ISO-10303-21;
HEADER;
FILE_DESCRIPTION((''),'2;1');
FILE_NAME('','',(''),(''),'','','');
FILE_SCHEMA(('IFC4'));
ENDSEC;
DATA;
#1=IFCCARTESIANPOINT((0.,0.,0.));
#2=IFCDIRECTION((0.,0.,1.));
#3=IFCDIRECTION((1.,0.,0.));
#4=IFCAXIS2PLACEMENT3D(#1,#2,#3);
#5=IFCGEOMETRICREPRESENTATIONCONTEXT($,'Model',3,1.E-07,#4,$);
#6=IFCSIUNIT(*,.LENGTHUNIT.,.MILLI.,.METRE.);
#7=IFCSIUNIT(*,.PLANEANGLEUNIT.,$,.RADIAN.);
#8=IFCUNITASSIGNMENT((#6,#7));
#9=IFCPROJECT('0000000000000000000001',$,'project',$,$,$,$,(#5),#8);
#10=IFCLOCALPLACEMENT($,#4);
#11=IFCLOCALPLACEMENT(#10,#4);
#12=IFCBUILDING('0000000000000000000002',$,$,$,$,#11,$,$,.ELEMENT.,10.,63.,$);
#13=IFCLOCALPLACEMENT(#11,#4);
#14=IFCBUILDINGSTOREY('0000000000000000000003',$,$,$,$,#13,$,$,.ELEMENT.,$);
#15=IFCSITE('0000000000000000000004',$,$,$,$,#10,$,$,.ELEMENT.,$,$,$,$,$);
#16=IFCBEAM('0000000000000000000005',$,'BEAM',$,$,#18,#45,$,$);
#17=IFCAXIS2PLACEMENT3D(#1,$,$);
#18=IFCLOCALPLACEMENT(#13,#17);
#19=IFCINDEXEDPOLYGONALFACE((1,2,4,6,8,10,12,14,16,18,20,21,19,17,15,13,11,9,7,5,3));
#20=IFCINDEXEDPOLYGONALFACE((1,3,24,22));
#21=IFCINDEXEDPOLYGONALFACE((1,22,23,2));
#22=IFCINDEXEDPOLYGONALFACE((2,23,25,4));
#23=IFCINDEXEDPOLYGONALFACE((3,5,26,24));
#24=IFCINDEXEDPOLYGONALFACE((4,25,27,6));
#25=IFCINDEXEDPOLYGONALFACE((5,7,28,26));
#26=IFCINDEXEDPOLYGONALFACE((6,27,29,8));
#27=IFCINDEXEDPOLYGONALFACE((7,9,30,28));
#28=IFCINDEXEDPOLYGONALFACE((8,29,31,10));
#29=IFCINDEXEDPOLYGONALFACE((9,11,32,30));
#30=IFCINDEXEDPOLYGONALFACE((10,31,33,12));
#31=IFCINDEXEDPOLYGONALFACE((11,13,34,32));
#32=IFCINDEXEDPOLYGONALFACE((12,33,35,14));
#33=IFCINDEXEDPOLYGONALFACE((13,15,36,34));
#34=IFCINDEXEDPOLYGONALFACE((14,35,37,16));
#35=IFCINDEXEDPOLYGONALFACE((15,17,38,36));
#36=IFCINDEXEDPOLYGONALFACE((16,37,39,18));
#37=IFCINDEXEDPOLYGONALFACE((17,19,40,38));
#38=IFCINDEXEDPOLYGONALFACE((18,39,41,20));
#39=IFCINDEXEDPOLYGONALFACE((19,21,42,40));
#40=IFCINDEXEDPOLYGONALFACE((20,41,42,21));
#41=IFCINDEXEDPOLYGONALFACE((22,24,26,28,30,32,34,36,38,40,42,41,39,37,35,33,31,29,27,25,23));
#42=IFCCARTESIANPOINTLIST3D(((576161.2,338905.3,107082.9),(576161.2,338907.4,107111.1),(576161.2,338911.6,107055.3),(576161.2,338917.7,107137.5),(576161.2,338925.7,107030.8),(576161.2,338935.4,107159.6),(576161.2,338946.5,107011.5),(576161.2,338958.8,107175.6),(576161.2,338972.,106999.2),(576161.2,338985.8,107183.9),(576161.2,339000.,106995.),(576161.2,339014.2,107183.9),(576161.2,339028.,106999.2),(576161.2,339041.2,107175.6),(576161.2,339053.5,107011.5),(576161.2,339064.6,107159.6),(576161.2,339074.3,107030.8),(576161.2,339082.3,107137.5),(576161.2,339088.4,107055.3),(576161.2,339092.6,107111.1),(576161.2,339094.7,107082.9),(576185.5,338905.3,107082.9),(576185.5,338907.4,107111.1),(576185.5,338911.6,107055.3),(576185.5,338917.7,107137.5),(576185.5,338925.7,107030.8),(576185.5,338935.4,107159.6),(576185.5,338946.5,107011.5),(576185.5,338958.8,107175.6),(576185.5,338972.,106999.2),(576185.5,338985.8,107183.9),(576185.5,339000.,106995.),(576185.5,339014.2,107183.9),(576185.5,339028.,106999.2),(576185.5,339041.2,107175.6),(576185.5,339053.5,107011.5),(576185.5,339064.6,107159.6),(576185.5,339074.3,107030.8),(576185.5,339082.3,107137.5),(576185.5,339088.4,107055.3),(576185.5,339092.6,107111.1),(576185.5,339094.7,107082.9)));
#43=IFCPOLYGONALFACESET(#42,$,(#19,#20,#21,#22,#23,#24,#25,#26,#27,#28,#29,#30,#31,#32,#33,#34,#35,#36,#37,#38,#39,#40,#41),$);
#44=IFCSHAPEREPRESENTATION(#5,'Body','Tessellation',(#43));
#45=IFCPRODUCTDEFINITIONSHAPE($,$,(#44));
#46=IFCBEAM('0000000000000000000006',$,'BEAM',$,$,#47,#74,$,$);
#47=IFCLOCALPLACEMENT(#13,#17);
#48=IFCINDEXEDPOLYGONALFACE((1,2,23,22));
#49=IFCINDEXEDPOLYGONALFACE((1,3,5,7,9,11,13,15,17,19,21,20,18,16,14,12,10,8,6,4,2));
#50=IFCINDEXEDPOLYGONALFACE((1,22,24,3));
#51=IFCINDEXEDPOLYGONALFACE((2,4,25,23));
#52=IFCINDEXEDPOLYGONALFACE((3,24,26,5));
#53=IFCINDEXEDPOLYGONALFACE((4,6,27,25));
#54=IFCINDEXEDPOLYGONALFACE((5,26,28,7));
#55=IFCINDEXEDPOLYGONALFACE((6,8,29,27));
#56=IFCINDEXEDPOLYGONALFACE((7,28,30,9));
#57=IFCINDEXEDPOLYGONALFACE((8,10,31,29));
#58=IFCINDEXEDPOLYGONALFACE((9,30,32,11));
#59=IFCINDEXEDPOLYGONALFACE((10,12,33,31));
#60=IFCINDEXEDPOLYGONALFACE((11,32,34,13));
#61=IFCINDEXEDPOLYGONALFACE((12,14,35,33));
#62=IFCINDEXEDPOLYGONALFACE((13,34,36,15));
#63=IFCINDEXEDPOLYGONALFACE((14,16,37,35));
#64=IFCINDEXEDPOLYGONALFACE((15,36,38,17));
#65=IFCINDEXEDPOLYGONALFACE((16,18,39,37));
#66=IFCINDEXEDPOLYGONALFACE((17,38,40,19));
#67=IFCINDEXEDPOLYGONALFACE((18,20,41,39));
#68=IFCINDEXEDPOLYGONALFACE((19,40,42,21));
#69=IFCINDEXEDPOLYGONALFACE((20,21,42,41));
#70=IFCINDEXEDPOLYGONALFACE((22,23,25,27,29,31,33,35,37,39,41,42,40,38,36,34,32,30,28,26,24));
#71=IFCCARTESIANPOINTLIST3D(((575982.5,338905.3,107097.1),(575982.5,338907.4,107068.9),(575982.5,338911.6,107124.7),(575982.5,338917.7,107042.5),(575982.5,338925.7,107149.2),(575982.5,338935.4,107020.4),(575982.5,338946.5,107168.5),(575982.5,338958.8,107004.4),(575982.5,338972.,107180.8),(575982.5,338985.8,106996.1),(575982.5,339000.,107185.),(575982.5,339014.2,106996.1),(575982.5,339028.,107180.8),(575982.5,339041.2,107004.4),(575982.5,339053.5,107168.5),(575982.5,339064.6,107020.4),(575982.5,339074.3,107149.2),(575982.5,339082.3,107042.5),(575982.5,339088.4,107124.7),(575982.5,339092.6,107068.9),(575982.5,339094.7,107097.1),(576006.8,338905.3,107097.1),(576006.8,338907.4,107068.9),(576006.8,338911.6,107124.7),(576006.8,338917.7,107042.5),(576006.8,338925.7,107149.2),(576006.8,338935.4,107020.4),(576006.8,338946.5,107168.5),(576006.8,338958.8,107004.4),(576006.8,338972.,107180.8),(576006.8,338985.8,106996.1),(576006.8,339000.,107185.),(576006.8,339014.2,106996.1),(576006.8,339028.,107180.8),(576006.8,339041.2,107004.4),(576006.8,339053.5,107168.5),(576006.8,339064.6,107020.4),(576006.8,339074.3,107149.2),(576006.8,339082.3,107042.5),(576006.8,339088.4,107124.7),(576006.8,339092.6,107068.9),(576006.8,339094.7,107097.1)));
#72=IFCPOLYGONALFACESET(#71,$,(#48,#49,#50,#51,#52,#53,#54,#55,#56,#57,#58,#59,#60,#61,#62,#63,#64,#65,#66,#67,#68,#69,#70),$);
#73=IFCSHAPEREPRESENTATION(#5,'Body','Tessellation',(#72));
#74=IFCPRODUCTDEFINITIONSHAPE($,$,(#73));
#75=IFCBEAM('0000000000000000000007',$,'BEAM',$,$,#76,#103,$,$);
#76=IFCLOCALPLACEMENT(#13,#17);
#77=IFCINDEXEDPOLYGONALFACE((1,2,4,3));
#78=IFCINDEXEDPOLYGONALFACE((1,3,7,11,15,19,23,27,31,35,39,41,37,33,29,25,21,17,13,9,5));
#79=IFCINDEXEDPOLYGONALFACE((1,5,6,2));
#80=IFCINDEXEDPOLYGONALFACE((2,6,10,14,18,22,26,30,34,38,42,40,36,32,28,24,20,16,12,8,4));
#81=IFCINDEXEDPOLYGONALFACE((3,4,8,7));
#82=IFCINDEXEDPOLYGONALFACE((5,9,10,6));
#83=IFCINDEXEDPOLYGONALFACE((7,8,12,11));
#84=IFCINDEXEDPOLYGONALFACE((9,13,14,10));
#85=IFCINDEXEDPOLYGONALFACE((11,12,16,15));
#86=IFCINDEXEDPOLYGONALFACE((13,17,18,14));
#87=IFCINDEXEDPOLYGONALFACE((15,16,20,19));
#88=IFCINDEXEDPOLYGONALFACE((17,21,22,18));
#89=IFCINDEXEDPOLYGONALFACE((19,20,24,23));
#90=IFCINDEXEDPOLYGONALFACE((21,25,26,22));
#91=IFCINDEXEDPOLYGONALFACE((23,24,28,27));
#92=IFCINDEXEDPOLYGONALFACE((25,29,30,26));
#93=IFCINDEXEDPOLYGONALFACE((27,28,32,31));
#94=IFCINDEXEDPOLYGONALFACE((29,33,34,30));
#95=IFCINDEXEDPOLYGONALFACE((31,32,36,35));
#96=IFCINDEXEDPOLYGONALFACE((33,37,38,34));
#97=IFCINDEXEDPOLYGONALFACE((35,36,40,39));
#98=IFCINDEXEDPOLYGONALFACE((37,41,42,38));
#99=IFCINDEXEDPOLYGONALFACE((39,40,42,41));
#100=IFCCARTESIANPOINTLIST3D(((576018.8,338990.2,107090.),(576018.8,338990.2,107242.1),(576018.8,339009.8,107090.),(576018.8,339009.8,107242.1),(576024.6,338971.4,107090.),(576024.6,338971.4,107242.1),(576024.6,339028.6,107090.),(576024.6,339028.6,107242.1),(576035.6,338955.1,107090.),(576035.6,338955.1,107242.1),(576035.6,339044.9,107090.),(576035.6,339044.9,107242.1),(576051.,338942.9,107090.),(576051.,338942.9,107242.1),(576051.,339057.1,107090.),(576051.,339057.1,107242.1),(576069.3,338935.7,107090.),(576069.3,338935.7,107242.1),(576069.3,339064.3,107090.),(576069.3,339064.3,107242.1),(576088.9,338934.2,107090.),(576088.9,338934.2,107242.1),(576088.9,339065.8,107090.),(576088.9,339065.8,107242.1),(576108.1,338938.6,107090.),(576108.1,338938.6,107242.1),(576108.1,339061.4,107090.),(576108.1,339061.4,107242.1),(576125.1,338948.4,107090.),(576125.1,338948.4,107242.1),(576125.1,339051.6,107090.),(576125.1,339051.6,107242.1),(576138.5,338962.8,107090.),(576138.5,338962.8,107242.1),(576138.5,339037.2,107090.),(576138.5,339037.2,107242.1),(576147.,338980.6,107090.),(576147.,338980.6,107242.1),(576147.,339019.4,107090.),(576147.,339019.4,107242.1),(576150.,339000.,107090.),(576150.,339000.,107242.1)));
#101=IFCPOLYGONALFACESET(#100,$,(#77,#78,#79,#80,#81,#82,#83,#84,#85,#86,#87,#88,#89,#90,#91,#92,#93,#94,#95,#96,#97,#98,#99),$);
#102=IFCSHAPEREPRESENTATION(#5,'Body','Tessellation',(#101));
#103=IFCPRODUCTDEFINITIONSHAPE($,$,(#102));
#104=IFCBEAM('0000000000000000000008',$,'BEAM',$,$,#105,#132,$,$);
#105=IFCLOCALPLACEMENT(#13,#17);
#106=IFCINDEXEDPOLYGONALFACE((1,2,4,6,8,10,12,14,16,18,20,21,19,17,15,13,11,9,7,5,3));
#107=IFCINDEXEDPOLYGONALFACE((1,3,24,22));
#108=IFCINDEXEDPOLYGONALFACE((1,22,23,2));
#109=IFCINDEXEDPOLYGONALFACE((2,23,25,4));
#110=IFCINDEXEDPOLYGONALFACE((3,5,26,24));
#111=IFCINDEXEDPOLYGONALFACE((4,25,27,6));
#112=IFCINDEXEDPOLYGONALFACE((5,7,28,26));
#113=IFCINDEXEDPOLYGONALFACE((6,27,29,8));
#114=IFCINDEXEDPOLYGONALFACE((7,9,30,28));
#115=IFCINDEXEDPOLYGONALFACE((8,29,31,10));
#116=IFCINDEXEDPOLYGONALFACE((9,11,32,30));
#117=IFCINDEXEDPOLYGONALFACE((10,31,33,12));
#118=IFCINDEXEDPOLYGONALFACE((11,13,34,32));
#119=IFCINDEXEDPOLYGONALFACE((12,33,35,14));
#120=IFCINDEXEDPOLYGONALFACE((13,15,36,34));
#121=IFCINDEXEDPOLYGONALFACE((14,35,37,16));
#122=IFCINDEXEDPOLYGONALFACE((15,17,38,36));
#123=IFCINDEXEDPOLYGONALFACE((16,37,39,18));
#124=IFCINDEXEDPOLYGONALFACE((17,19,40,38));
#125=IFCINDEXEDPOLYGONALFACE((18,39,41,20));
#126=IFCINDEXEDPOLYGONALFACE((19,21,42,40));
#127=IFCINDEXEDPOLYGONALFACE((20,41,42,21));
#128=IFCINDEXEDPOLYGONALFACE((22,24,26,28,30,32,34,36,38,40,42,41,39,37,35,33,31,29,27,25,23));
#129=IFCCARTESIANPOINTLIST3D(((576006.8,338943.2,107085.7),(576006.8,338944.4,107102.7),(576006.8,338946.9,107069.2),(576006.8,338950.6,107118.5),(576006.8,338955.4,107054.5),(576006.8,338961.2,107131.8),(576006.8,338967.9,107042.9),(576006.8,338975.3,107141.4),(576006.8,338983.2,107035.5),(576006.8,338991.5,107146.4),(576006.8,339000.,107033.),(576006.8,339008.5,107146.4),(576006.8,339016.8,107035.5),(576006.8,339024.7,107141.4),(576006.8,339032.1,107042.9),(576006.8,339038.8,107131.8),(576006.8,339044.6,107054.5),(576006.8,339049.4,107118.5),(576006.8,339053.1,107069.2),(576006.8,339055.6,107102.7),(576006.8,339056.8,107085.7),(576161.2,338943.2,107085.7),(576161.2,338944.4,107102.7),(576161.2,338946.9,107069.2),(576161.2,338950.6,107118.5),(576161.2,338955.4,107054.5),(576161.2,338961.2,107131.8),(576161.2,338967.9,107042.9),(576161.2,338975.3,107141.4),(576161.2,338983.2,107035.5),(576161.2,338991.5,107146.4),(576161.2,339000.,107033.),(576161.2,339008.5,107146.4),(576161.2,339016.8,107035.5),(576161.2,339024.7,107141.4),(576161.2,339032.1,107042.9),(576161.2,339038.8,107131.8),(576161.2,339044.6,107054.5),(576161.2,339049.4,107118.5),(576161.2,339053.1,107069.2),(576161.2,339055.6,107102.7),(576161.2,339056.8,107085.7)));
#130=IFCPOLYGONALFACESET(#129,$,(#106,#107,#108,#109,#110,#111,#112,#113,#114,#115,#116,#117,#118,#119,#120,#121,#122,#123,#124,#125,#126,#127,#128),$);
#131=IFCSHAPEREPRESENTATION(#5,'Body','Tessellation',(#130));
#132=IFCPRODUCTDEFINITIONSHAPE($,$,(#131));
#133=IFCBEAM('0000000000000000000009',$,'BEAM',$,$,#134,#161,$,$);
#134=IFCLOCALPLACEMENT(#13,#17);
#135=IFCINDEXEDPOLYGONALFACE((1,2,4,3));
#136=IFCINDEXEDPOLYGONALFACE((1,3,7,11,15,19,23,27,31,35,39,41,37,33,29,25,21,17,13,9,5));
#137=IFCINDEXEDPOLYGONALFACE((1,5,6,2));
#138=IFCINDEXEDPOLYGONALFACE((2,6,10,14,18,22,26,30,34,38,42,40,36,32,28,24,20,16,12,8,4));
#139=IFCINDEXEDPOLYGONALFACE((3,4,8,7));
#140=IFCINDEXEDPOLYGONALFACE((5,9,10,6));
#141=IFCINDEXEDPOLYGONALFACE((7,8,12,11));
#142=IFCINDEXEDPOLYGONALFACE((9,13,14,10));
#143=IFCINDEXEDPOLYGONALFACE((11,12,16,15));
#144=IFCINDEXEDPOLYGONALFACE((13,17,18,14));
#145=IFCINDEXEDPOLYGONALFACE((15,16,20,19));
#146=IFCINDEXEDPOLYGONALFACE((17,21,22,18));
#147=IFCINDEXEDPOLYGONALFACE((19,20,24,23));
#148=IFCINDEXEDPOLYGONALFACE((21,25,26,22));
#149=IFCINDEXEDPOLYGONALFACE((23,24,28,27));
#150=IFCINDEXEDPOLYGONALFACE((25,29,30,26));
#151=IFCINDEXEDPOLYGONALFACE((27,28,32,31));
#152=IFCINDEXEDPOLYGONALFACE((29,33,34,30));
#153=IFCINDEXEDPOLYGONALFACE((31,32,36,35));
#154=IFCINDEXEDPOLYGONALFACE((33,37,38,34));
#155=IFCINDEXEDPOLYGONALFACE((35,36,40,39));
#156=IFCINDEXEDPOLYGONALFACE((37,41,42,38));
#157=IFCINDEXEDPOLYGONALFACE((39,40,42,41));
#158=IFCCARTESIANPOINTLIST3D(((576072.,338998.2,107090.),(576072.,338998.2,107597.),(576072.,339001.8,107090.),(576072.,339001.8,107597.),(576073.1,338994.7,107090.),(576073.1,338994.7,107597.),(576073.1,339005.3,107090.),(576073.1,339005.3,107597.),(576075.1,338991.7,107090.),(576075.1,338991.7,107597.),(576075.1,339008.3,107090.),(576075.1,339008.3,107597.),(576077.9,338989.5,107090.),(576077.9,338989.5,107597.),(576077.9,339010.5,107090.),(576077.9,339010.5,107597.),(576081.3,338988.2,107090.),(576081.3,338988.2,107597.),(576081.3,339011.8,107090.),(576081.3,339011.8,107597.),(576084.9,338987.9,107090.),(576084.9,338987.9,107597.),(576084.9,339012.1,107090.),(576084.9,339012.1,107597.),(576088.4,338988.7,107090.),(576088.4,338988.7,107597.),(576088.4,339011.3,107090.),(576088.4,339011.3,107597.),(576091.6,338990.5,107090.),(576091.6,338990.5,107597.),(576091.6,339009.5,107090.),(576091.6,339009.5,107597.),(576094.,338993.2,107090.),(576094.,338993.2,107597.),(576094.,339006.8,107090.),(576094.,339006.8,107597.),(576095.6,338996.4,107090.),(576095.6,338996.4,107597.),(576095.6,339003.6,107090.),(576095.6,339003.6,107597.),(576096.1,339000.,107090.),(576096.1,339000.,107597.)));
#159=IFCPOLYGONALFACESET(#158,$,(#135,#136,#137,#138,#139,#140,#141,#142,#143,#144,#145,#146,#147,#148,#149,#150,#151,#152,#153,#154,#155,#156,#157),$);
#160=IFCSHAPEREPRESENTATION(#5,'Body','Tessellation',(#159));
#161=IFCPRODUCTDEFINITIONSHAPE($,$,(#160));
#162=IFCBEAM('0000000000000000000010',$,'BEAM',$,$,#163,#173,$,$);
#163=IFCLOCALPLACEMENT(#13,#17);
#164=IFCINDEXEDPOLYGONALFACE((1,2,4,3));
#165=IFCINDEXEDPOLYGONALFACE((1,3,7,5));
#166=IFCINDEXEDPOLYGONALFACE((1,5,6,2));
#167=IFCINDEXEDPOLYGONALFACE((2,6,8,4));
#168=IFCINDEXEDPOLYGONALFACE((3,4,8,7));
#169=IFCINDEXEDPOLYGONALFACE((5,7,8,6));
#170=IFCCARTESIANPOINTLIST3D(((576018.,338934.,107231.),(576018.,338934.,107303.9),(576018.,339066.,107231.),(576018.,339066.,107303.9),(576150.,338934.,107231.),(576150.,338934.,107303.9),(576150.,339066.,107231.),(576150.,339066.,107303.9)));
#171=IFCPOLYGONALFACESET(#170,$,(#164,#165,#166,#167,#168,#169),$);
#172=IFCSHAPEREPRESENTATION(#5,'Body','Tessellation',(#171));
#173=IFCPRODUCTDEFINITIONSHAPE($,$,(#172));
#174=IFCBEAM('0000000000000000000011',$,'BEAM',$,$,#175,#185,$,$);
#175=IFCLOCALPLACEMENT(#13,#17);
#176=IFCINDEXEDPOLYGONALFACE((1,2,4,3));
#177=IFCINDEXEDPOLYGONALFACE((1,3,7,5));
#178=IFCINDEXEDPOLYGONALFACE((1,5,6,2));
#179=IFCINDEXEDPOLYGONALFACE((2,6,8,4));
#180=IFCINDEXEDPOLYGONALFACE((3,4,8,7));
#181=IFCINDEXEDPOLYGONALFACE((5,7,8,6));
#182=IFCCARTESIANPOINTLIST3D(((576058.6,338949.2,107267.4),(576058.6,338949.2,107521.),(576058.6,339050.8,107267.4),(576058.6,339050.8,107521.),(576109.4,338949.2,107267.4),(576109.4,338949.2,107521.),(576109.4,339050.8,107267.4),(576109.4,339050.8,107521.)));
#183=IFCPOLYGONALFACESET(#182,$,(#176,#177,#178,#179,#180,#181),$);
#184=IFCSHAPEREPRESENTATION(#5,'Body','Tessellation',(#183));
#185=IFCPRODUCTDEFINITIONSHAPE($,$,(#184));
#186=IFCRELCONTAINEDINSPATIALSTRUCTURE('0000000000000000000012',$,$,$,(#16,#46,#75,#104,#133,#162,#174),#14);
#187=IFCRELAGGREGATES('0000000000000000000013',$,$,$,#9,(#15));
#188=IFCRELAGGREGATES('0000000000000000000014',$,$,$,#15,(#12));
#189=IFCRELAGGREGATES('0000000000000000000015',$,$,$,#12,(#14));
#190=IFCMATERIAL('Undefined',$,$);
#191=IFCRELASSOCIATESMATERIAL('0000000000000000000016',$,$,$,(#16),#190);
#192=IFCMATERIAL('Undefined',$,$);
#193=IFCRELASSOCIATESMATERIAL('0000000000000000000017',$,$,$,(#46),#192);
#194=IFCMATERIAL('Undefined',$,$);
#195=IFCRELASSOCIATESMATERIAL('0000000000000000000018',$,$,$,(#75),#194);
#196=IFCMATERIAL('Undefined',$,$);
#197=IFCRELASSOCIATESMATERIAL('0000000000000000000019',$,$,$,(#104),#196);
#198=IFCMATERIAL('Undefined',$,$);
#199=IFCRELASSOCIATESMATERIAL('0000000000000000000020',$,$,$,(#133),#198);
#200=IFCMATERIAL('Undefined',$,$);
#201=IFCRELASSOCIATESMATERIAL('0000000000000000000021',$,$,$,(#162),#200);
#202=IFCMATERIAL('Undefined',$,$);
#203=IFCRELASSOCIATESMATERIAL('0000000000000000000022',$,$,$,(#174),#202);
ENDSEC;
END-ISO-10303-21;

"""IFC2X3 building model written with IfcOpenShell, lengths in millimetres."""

from ifc_helpers import new_model, si_unit, frame, origin_with_axes, origin_2d_with_axis, place, context, project, spatial, rectangle, circle, extrude, material, element, save


model = new_model("IFC2X3")

# Units and contexts
model_context = context("Model", 3, precision=1e-07, world=origin_with_axes())
ifc_project = project(units=[si_unit("LENGTHUNIT", "METRE", prefix="MILLI"), si_unit("PLANEANGLEUNIT", "RADIAN")], contexts=[model_context])

# Site, building, storey
site_placement = place(None, origin_with_axes())
site = spatial("IfcSite", under=ifc_project, at=site_placement, CompositionType="ELEMENT")
building_placement = place(site_placement, origin_with_axes())
building = spatial("IfcBuilding", under=site, at=building_placement, CompositionType="ELEMENT", ElevationOfRefHeight=10.0, ElevationOfTerrain=63.0)
storey_placement = place(building_placement, origin_with_axes())
storey = spatial("IfcBuildingStorey", under=building, at=storey_placement, CompositionType="ELEMENT")

# Beams
ifc_material_1 = material(Name="Undefined")
beam_1_placement = place(storey_placement, frame((576173.3, 339000.0, 107090.0), z_axis=(1.0, 0.0, 0.0), x_axis=(0.0, 1.0, 0.0)))
element("IfcBeam", 1, at=beam_1_placement, inside=storey, material=ifc_material_1, Name="BEAM", context=model_context, shape_type="SweptSolid", body=[
    extrude(circle(Radius=95.0, at=origin_2d_with_axis()), frame((0.0, 0.0, -12.2), z_axis=(0.0, 0.0, 1.0), x_axis=(0.0, -1.0, 0.0)), (0.0, 0.0, 1.0), 24.3),
])
ifc_material_2 = material(Name="Undefined")
beam_2_placement = place(storey_placement, frame((575994.6, 339000.0, 107090.0), z_axis=(-1.0, 0.0, 0.0), x_axis=(0.0, 1.0, 0.0)))
element("IfcBeam", 2, at=beam_2_placement, inside=storey, material=ifc_material_2, Name="BEAM", context=model_context, shape_type="SweptSolid", body=[
    extrude(circle(Radius=95.0, at=origin_2d_with_axis()), frame((0.0, 0.0, -12.2), z_axis=(0.0, 0.0, 1.0), x_axis=(0.0, -1.0, 0.0)), (0.0, 0.0, 1.0), 24.3),
])
ifc_material_3 = material(Name="Undefined")
beam_3_placement = place(storey_placement, frame((576084.0, 339000.0, 107166.1), z_axis=(0.0, 0.0, 1.0), x_axis=(0.0, 1.0, 0.0)))
element("IfcBeam", 3, at=beam_3_placement, inside=storey, material=ifc_material_3, Name="BEAM", context=model_context, shape_type="SweptSolid", body=[
    extrude(circle(Radius=66.0, at=origin_2d_with_axis()), frame((0.0, 0.0, -76.0), z_axis=(0.0, 0.0, 1.0), x_axis=(0.0, -1.0, 0.0)), (0.0, 0.0, 1.0), 152.1),
])
ifc_material_4 = material(Name="Undefined")
beam_4_placement = place(storey_placement, frame((576084.0, 339000.0, 107090.0), z_axis=(1.0, 0.0, 0.0), x_axis=(0.0, 1.0, 0.0)))
element("IfcBeam", 4, at=beam_4_placement, inside=storey, material=ifc_material_4, Name="BEAM", context=model_context, shape_type="SweptSolid", body=[
    extrude(circle(Radius=57.0, at=origin_2d_with_axis()), frame((0.0, 0.0, -77.2), z_axis=(0.0, 0.0, 1.0), x_axis=(0.0, -1.0, 0.0)), (0.0, 0.0, 1.0), 154.4),
])
ifc_material_5 = material(Name="Undefined")
beam_5_placement = place(storey_placement, frame((576084.0, 339000.0, 107343.5), z_axis=(0.0, 0.0, 1.0), x_axis=(0.0, 1.0, 0.0)))
element("IfcBeam", 5, at=beam_5_placement, inside=storey, material=ifc_material_5, Name="BEAM", context=model_context, shape_type="SweptSolid", body=[
    extrude(circle(Radius=12.2, at=origin_2d_with_axis()), frame((0.0, 0.0, -253.5), z_axis=(0.0, 0.0, 1.0), x_axis=(0.0, -1.0, 0.0)), (0.0, 0.0, 1.0), 507.0),
])
ifc_material_6 = material(Name="Undefined")
beam_6_placement = place(storey_placement, frame((576084.0, 339000.0, 107267.4), z_axis=(0.0, 0.0, 1.0), x_axis=(0.0, -1.0, 0.0)))
element("IfcBeam", 6, at=beam_6_placement, inside=storey, material=ifc_material_6, Name="BEAM", context=model_context, shape_type="SweptSolid", body=[
    extrude(rectangle(XDim=131.9, YDim=131.9, at=origin_2d_with_axis()), frame((0.0, 0.0, -36.5), z_axis=(0.0, 0.0, 1.0), x_axis=(0.0, -1.0, 0.0)), (0.0, 0.0, 1.0), 72.9),
])
ifc_material_7 = material(Name="Undefined")
beam_7_placement = place(storey_placement, frame((576084.0, 339000.0, 107394.2), z_axis=(0.0, 0.0, 1.0), x_axis=(0.0, -1.0, 0.0)))
element("IfcBeam", 7, at=beam_7_placement, inside=storey, material=ifc_material_7, Name="BEAM", context=model_context, shape_type="SweptSolid", body=[
    extrude(rectangle(XDim=50.8, YDim=101.5, at=origin_2d_with_axis()), frame((0.0, 0.0, -126.8), z_axis=(0.0, 0.0, 1.0), x_axis=(0.0, -1.0, 0.0)), (0.0, 0.0, 1.0), 253.5),
])

save(model, "model.ifc")
